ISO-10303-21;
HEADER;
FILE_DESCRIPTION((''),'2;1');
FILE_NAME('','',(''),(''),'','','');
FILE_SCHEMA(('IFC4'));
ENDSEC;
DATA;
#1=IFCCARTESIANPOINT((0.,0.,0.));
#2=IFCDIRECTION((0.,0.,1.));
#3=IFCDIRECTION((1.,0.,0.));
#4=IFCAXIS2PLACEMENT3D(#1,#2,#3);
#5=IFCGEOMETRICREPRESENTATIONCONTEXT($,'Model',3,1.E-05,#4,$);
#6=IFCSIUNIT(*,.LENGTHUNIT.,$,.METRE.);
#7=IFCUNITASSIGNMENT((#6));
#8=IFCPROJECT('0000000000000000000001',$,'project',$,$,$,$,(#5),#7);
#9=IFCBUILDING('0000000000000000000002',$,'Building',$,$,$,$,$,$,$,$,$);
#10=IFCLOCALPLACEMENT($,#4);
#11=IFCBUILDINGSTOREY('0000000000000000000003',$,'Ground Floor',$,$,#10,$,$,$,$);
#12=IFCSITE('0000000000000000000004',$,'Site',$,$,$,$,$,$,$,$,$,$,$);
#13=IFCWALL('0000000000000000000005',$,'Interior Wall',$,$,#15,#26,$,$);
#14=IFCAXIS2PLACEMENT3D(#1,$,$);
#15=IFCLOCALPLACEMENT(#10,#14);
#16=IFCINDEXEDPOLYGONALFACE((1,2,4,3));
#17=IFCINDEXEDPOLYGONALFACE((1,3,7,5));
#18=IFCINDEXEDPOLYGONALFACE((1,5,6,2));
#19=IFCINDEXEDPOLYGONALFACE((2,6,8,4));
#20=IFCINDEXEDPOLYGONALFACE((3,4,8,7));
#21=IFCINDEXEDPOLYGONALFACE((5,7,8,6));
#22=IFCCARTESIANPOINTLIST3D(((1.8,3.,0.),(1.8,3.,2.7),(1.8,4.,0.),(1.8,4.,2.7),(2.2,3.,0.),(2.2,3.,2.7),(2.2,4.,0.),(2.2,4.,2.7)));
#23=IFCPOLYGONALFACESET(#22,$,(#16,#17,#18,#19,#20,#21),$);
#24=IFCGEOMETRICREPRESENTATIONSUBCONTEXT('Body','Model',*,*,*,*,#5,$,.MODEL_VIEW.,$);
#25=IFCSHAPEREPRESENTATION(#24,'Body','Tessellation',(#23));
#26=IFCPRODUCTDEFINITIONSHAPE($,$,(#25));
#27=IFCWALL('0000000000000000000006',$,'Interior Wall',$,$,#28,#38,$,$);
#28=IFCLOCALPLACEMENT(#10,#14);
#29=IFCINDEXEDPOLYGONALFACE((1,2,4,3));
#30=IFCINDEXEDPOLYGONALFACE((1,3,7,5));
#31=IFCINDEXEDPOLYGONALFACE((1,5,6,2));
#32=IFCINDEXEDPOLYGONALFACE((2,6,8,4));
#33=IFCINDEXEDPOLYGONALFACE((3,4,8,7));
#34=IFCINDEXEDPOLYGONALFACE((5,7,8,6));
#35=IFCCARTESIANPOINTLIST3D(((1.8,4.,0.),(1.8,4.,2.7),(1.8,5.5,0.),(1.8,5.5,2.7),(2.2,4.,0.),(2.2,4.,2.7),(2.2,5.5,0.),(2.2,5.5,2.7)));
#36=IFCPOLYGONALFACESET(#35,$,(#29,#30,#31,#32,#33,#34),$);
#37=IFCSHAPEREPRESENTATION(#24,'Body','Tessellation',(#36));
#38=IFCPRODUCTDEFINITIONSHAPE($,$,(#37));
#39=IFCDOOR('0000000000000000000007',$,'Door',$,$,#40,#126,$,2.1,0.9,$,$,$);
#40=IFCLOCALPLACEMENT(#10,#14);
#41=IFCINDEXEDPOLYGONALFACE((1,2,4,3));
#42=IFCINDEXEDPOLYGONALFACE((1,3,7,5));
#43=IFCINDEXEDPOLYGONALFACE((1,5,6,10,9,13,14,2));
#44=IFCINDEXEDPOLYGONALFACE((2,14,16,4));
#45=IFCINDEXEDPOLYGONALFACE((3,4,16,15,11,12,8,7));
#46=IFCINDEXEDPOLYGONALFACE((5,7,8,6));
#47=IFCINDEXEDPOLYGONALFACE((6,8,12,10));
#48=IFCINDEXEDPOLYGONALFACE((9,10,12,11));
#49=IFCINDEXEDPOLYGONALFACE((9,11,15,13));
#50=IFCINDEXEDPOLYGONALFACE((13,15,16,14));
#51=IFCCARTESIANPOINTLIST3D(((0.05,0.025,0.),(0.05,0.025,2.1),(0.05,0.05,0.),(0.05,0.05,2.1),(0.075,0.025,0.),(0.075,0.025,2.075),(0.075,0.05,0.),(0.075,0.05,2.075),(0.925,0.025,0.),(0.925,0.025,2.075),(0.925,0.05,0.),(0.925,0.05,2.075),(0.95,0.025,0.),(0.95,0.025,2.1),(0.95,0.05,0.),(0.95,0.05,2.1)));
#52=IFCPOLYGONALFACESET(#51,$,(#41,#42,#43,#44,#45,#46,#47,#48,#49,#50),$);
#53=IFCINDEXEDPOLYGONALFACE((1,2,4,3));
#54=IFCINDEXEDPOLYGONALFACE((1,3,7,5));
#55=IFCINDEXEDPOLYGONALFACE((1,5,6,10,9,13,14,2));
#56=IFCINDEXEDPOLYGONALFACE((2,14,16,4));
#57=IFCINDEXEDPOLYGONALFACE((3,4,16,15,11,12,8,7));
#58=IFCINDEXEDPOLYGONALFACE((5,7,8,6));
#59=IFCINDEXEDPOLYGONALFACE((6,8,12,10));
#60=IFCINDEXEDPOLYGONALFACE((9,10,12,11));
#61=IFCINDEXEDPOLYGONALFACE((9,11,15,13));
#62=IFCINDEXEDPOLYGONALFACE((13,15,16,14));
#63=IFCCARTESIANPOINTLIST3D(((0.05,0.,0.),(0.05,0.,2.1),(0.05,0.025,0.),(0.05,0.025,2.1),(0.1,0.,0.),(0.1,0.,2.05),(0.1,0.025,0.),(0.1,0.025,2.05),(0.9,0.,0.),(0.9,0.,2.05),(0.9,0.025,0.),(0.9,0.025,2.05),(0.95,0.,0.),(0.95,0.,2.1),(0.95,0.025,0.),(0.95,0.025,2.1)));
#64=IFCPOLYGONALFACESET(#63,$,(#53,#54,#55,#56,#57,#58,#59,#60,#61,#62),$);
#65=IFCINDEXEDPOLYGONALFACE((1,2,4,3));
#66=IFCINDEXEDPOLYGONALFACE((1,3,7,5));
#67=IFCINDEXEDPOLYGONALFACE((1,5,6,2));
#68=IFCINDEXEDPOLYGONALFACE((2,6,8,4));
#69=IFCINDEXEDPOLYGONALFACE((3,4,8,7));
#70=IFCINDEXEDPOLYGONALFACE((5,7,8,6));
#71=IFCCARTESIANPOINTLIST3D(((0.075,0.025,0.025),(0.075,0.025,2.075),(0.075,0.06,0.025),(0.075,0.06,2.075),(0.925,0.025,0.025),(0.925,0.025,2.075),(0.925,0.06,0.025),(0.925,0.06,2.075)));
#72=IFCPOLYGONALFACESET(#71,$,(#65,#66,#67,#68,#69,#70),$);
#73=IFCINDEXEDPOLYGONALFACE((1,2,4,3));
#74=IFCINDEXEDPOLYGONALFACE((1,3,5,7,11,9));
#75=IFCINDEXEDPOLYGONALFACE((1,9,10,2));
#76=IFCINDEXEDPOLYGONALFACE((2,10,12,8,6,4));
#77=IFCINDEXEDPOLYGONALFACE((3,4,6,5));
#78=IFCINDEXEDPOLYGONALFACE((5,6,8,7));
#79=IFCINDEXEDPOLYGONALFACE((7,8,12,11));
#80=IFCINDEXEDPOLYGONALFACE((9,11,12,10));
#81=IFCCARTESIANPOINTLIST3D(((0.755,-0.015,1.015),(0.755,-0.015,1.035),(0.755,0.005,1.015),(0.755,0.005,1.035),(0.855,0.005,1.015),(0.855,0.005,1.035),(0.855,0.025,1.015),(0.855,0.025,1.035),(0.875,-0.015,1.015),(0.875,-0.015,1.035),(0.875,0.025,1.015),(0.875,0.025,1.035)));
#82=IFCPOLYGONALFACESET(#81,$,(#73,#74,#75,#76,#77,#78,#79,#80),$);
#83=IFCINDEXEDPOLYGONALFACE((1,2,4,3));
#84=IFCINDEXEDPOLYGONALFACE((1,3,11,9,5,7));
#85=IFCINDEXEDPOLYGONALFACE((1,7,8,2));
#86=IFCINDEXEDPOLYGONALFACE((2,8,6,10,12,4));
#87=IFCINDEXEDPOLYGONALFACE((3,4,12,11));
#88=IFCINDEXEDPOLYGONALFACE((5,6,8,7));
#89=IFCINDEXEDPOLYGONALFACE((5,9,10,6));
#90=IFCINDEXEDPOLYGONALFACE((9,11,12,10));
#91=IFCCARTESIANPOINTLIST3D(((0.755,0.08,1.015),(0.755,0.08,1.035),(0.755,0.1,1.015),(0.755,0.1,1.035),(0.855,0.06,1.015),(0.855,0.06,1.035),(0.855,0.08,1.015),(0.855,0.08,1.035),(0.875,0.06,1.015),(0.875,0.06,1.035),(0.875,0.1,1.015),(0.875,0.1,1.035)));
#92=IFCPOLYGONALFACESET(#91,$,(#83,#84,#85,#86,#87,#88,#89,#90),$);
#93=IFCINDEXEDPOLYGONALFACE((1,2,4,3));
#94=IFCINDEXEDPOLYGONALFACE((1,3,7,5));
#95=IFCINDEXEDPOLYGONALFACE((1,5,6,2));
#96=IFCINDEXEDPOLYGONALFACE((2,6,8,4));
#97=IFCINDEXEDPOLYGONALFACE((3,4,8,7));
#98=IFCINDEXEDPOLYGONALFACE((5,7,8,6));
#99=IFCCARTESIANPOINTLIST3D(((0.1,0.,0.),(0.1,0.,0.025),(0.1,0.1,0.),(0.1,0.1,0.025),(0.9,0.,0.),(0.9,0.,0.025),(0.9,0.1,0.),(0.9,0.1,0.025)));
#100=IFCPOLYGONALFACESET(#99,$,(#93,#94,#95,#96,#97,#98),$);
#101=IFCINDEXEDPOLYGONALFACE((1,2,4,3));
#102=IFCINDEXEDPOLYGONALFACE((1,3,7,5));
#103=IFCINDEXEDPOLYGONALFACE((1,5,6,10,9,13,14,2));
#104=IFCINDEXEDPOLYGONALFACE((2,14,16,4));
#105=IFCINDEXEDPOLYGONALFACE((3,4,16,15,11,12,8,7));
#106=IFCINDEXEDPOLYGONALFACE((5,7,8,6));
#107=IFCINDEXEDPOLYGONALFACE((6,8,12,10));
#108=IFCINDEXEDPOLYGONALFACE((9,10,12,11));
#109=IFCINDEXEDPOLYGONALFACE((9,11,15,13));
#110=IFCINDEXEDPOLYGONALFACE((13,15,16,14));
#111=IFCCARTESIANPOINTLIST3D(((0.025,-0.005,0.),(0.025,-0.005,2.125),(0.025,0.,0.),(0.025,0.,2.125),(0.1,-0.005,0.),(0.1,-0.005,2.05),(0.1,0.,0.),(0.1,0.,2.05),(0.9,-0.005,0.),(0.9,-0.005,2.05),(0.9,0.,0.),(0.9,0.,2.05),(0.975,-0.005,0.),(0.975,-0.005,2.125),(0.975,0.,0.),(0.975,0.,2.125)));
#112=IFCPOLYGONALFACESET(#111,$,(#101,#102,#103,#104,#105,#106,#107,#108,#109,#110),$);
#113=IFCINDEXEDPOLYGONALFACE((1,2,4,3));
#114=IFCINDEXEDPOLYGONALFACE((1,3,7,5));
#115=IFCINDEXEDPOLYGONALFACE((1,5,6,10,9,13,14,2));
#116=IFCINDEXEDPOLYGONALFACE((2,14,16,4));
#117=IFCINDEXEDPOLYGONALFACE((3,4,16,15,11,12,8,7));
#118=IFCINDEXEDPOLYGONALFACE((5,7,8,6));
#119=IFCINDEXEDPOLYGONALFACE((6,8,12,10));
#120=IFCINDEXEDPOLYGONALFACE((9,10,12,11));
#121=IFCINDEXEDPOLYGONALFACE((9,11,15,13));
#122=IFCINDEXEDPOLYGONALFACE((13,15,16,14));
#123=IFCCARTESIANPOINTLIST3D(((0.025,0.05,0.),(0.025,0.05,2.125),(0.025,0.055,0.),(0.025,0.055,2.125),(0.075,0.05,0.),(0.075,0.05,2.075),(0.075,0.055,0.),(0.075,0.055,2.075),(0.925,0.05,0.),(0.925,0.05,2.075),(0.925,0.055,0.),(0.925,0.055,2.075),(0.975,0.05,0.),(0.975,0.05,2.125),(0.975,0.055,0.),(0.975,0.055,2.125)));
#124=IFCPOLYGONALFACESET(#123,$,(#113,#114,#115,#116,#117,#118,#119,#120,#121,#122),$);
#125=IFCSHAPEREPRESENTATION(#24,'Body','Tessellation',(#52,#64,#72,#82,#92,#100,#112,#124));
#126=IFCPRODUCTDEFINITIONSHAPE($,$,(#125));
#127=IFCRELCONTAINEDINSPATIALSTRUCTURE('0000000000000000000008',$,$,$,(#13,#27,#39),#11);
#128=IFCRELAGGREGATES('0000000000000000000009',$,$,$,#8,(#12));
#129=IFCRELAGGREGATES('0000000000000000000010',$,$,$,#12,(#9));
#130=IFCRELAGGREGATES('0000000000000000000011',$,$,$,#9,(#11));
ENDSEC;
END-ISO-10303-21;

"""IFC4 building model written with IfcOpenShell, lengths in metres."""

from ifc_helpers import new_model, si_unit, frame, origin_with_axes, place, context, subcontext, project, spatial, line, indexed_curve, outline, extrude, element, save


model = new_model("IFC4")

# Units and contexts
model_context = context("Model", 3, precision=1e-05, world=origin_with_axes())
body_context = subcontext(model_context, "Body", "Model", "MODEL_VIEW")
ifc_project = project(units=[si_unit("LENGTHUNIT", "METRE")], contexts=[model_context])

# Site, building, storey
site = spatial("IfcSite", under=ifc_project, Name="Site")
building = spatial("IfcBuilding", under=site, Name="Building")
storey_placement = place(None, origin_with_axes())
storey = spatial("IfcBuildingStorey", under=building, at=storey_placement, Name="Ground Floor")

# Walls
wall_1_placement = place(storey_placement, frame((2.0, 4.0, 0.0), z_axis=(0.0, 0.0, 1.0), x_axis=(0.0, -1.0, 0.0)))
element("IfcWall", 1, at=wall_1_placement, inside=storey, Name="Interior Wall", context=body_context, shape_type="SweptSolid", body=[
    extrude(outline(indexed_curve([(0.0, 0.0), (0.0, 0.4), (1.0, 0.4), (1.0, 0.0), (0.0, 0.0)], self_intersect=False)), frame((0.0, -0.2, 0.0), z_axis=(0.0, 0.0, 1.0), x_axis=(1.0, 0.0, 0.0)), (0.0, 0.0, 1.0), 2.7),
])
wall_2_placement = place(storey_placement, frame((2.0, 4.0, 0.0), z_axis=(0.0, 0.0, 1.0), x_axis=(0.0, 1.0, 0.0)))
element("IfcWall", 2, at=wall_2_placement, inside=storey, Name="Interior Wall", context=body_context, shape_type="SweptSolid", body=[
    extrude(outline(indexed_curve([(0.0, 0.0), (0.0, 0.4), (1.5, 0.4), (1.5, 0.0), (0.0, 0.0)], self_intersect=False)), frame((0.0, -0.2, 0.0), z_axis=(0.0, 0.0, 1.0), x_axis=(1.0, 0.0, 0.0)), (0.0, 0.0, 1.0), 2.7),
])

# Door
door_1_placement = place(storey_placement, frame((0.05, 0.0, 0.0), z_axis=(0.0, 0.0, 1.0), x_axis=(1.0, 0.0, 0.0)))
element("IfcDoor", 3, at=door_1_placement, inside=storey, Name="Door", OverallHeight=2.1, OverallWidth=0.9, context=body_context, shape_type="SweptSolid", body=[
    extrude(outline(indexed_curve([(0.0, 0.0), (0.0, 2.1), (0.9, 2.1), (0.9, 0.0), (0.875, 0.0), (0.875, 2.075), (0.025, 2.075), (0.025, 0.0)], segments=[line(1, 2, 3, 4, 5, 6, 7, 8, 1)])), frame((0.0, 0.025, 0.0), z_axis=(0.0, -1.0, 0.0), x_axis=(1.0, 0.0, 0.0)), (0.0, 0.0, -1.0), 0.025),
    extrude(outline(indexed_curve([(0.0, 0.0), (0.0, 2.1), (0.9, 2.1), (0.9, 0.0), (0.85, 0.0), (0.85, 2.05), (0.05, 2.05), (0.05, 0.0)], segments=[line(1, 2, 3, 4, 5, 6, 7, 8, 1)])), frame((0.0, 0.0, 0.0), z_axis=(0.0, -1.0, 0.0), x_axis=(1.0, 0.0, 0.0)), (0.0, 0.0, -1.0), 0.025),
    extrude(outline(indexed_curve([(0.0, 0.0), (0.85, 0.0), (0.85, 0.035), (0.0, 0.035)], segments=[line(1, 2, 3, 4, 1)])), frame((0.025, 0.025, 0.025), z_axis=(0.0, 0.0, 1.0), x_axis=(1.0, 0.0, 0.0)), (0.0, 0.0, 1.0), 2.05),
    extrude(outline(indexed_curve([(0.0, 0.0), (0.0, -0.04), (-0.12, -0.04), (-0.12, -0.02), (-0.02, -0.02), (-0.02, 0.0)], segments=[line(1, 2, 3, 4, 5, 6, 1)])), frame((0.825, 0.025, 1.015), z_axis=(0.0, 0.0, 1.0), x_axis=(1.0, 0.0, 0.0)), (0.0, 0.0, 1.0), 0.02),
    extrude(outline(indexed_curve([(0.0, 0.0), (0.0, 0.04), (-0.12, 0.04), (-0.12, 0.02), (-0.02, 0.02), (-0.02, 0.0)], segments=[line(1, 2, 3, 4, 5, 6, 1)])), frame((0.825, 0.06, 1.015), z_axis=(0.0, 0.0, 1.0), x_axis=(1.0, 0.0, 0.0)), (0.0, 0.0, 1.0), 0.02),
    extrude(outline(indexed_curve([(0.0, 0.0), (0.8, 0.0), (0.8, 0.1), (0.0, 0.1)], segments=[line(1, 2, 3, 4, 1)])), frame((0.05, 0.0, 0.0), z_axis=(0.0, 0.0, 1.0), x_axis=(1.0, 0.0, 0.0)), (0.0, 0.0, 1.0), 0.025),
    extrude(outline(indexed_curve([(0.0, 0.0), (0.0, 2.125), (0.95, 2.125), (0.95, 0.0), (0.875, 0.0), (0.875, 2.05), (0.075, 2.05), (0.075, 0.0)], segments=[line(1, 2, 3, 4, 5, 6, 7, 8, 1)])), frame((-0.025, -0.005, 0.0), z_axis=(0.0, -1.0, 0.0), x_axis=(1.0, 0.0, 0.0)), (0.0, 0.0, -1.0), 0.005),
    extrude(outline(indexed_curve([(0.0, 0.0), (0.0, 2.125), (0.95, 2.125), (0.95, 0.0), (0.9, 0.0), (0.9, 2.075), (0.05, 2.075), (0.05, 0.0)], segments=[line(1, 2, 3, 4, 5, 6, 7, 8, 1)])), frame((-0.025, 0.05, 0.0), z_axis=(0.0, -1.0, 0.0), x_axis=(1.0, 0.0, 0.0)), (0.0, 0.0, -1.0), 0.005),
])

save(model, "model.ifc")
